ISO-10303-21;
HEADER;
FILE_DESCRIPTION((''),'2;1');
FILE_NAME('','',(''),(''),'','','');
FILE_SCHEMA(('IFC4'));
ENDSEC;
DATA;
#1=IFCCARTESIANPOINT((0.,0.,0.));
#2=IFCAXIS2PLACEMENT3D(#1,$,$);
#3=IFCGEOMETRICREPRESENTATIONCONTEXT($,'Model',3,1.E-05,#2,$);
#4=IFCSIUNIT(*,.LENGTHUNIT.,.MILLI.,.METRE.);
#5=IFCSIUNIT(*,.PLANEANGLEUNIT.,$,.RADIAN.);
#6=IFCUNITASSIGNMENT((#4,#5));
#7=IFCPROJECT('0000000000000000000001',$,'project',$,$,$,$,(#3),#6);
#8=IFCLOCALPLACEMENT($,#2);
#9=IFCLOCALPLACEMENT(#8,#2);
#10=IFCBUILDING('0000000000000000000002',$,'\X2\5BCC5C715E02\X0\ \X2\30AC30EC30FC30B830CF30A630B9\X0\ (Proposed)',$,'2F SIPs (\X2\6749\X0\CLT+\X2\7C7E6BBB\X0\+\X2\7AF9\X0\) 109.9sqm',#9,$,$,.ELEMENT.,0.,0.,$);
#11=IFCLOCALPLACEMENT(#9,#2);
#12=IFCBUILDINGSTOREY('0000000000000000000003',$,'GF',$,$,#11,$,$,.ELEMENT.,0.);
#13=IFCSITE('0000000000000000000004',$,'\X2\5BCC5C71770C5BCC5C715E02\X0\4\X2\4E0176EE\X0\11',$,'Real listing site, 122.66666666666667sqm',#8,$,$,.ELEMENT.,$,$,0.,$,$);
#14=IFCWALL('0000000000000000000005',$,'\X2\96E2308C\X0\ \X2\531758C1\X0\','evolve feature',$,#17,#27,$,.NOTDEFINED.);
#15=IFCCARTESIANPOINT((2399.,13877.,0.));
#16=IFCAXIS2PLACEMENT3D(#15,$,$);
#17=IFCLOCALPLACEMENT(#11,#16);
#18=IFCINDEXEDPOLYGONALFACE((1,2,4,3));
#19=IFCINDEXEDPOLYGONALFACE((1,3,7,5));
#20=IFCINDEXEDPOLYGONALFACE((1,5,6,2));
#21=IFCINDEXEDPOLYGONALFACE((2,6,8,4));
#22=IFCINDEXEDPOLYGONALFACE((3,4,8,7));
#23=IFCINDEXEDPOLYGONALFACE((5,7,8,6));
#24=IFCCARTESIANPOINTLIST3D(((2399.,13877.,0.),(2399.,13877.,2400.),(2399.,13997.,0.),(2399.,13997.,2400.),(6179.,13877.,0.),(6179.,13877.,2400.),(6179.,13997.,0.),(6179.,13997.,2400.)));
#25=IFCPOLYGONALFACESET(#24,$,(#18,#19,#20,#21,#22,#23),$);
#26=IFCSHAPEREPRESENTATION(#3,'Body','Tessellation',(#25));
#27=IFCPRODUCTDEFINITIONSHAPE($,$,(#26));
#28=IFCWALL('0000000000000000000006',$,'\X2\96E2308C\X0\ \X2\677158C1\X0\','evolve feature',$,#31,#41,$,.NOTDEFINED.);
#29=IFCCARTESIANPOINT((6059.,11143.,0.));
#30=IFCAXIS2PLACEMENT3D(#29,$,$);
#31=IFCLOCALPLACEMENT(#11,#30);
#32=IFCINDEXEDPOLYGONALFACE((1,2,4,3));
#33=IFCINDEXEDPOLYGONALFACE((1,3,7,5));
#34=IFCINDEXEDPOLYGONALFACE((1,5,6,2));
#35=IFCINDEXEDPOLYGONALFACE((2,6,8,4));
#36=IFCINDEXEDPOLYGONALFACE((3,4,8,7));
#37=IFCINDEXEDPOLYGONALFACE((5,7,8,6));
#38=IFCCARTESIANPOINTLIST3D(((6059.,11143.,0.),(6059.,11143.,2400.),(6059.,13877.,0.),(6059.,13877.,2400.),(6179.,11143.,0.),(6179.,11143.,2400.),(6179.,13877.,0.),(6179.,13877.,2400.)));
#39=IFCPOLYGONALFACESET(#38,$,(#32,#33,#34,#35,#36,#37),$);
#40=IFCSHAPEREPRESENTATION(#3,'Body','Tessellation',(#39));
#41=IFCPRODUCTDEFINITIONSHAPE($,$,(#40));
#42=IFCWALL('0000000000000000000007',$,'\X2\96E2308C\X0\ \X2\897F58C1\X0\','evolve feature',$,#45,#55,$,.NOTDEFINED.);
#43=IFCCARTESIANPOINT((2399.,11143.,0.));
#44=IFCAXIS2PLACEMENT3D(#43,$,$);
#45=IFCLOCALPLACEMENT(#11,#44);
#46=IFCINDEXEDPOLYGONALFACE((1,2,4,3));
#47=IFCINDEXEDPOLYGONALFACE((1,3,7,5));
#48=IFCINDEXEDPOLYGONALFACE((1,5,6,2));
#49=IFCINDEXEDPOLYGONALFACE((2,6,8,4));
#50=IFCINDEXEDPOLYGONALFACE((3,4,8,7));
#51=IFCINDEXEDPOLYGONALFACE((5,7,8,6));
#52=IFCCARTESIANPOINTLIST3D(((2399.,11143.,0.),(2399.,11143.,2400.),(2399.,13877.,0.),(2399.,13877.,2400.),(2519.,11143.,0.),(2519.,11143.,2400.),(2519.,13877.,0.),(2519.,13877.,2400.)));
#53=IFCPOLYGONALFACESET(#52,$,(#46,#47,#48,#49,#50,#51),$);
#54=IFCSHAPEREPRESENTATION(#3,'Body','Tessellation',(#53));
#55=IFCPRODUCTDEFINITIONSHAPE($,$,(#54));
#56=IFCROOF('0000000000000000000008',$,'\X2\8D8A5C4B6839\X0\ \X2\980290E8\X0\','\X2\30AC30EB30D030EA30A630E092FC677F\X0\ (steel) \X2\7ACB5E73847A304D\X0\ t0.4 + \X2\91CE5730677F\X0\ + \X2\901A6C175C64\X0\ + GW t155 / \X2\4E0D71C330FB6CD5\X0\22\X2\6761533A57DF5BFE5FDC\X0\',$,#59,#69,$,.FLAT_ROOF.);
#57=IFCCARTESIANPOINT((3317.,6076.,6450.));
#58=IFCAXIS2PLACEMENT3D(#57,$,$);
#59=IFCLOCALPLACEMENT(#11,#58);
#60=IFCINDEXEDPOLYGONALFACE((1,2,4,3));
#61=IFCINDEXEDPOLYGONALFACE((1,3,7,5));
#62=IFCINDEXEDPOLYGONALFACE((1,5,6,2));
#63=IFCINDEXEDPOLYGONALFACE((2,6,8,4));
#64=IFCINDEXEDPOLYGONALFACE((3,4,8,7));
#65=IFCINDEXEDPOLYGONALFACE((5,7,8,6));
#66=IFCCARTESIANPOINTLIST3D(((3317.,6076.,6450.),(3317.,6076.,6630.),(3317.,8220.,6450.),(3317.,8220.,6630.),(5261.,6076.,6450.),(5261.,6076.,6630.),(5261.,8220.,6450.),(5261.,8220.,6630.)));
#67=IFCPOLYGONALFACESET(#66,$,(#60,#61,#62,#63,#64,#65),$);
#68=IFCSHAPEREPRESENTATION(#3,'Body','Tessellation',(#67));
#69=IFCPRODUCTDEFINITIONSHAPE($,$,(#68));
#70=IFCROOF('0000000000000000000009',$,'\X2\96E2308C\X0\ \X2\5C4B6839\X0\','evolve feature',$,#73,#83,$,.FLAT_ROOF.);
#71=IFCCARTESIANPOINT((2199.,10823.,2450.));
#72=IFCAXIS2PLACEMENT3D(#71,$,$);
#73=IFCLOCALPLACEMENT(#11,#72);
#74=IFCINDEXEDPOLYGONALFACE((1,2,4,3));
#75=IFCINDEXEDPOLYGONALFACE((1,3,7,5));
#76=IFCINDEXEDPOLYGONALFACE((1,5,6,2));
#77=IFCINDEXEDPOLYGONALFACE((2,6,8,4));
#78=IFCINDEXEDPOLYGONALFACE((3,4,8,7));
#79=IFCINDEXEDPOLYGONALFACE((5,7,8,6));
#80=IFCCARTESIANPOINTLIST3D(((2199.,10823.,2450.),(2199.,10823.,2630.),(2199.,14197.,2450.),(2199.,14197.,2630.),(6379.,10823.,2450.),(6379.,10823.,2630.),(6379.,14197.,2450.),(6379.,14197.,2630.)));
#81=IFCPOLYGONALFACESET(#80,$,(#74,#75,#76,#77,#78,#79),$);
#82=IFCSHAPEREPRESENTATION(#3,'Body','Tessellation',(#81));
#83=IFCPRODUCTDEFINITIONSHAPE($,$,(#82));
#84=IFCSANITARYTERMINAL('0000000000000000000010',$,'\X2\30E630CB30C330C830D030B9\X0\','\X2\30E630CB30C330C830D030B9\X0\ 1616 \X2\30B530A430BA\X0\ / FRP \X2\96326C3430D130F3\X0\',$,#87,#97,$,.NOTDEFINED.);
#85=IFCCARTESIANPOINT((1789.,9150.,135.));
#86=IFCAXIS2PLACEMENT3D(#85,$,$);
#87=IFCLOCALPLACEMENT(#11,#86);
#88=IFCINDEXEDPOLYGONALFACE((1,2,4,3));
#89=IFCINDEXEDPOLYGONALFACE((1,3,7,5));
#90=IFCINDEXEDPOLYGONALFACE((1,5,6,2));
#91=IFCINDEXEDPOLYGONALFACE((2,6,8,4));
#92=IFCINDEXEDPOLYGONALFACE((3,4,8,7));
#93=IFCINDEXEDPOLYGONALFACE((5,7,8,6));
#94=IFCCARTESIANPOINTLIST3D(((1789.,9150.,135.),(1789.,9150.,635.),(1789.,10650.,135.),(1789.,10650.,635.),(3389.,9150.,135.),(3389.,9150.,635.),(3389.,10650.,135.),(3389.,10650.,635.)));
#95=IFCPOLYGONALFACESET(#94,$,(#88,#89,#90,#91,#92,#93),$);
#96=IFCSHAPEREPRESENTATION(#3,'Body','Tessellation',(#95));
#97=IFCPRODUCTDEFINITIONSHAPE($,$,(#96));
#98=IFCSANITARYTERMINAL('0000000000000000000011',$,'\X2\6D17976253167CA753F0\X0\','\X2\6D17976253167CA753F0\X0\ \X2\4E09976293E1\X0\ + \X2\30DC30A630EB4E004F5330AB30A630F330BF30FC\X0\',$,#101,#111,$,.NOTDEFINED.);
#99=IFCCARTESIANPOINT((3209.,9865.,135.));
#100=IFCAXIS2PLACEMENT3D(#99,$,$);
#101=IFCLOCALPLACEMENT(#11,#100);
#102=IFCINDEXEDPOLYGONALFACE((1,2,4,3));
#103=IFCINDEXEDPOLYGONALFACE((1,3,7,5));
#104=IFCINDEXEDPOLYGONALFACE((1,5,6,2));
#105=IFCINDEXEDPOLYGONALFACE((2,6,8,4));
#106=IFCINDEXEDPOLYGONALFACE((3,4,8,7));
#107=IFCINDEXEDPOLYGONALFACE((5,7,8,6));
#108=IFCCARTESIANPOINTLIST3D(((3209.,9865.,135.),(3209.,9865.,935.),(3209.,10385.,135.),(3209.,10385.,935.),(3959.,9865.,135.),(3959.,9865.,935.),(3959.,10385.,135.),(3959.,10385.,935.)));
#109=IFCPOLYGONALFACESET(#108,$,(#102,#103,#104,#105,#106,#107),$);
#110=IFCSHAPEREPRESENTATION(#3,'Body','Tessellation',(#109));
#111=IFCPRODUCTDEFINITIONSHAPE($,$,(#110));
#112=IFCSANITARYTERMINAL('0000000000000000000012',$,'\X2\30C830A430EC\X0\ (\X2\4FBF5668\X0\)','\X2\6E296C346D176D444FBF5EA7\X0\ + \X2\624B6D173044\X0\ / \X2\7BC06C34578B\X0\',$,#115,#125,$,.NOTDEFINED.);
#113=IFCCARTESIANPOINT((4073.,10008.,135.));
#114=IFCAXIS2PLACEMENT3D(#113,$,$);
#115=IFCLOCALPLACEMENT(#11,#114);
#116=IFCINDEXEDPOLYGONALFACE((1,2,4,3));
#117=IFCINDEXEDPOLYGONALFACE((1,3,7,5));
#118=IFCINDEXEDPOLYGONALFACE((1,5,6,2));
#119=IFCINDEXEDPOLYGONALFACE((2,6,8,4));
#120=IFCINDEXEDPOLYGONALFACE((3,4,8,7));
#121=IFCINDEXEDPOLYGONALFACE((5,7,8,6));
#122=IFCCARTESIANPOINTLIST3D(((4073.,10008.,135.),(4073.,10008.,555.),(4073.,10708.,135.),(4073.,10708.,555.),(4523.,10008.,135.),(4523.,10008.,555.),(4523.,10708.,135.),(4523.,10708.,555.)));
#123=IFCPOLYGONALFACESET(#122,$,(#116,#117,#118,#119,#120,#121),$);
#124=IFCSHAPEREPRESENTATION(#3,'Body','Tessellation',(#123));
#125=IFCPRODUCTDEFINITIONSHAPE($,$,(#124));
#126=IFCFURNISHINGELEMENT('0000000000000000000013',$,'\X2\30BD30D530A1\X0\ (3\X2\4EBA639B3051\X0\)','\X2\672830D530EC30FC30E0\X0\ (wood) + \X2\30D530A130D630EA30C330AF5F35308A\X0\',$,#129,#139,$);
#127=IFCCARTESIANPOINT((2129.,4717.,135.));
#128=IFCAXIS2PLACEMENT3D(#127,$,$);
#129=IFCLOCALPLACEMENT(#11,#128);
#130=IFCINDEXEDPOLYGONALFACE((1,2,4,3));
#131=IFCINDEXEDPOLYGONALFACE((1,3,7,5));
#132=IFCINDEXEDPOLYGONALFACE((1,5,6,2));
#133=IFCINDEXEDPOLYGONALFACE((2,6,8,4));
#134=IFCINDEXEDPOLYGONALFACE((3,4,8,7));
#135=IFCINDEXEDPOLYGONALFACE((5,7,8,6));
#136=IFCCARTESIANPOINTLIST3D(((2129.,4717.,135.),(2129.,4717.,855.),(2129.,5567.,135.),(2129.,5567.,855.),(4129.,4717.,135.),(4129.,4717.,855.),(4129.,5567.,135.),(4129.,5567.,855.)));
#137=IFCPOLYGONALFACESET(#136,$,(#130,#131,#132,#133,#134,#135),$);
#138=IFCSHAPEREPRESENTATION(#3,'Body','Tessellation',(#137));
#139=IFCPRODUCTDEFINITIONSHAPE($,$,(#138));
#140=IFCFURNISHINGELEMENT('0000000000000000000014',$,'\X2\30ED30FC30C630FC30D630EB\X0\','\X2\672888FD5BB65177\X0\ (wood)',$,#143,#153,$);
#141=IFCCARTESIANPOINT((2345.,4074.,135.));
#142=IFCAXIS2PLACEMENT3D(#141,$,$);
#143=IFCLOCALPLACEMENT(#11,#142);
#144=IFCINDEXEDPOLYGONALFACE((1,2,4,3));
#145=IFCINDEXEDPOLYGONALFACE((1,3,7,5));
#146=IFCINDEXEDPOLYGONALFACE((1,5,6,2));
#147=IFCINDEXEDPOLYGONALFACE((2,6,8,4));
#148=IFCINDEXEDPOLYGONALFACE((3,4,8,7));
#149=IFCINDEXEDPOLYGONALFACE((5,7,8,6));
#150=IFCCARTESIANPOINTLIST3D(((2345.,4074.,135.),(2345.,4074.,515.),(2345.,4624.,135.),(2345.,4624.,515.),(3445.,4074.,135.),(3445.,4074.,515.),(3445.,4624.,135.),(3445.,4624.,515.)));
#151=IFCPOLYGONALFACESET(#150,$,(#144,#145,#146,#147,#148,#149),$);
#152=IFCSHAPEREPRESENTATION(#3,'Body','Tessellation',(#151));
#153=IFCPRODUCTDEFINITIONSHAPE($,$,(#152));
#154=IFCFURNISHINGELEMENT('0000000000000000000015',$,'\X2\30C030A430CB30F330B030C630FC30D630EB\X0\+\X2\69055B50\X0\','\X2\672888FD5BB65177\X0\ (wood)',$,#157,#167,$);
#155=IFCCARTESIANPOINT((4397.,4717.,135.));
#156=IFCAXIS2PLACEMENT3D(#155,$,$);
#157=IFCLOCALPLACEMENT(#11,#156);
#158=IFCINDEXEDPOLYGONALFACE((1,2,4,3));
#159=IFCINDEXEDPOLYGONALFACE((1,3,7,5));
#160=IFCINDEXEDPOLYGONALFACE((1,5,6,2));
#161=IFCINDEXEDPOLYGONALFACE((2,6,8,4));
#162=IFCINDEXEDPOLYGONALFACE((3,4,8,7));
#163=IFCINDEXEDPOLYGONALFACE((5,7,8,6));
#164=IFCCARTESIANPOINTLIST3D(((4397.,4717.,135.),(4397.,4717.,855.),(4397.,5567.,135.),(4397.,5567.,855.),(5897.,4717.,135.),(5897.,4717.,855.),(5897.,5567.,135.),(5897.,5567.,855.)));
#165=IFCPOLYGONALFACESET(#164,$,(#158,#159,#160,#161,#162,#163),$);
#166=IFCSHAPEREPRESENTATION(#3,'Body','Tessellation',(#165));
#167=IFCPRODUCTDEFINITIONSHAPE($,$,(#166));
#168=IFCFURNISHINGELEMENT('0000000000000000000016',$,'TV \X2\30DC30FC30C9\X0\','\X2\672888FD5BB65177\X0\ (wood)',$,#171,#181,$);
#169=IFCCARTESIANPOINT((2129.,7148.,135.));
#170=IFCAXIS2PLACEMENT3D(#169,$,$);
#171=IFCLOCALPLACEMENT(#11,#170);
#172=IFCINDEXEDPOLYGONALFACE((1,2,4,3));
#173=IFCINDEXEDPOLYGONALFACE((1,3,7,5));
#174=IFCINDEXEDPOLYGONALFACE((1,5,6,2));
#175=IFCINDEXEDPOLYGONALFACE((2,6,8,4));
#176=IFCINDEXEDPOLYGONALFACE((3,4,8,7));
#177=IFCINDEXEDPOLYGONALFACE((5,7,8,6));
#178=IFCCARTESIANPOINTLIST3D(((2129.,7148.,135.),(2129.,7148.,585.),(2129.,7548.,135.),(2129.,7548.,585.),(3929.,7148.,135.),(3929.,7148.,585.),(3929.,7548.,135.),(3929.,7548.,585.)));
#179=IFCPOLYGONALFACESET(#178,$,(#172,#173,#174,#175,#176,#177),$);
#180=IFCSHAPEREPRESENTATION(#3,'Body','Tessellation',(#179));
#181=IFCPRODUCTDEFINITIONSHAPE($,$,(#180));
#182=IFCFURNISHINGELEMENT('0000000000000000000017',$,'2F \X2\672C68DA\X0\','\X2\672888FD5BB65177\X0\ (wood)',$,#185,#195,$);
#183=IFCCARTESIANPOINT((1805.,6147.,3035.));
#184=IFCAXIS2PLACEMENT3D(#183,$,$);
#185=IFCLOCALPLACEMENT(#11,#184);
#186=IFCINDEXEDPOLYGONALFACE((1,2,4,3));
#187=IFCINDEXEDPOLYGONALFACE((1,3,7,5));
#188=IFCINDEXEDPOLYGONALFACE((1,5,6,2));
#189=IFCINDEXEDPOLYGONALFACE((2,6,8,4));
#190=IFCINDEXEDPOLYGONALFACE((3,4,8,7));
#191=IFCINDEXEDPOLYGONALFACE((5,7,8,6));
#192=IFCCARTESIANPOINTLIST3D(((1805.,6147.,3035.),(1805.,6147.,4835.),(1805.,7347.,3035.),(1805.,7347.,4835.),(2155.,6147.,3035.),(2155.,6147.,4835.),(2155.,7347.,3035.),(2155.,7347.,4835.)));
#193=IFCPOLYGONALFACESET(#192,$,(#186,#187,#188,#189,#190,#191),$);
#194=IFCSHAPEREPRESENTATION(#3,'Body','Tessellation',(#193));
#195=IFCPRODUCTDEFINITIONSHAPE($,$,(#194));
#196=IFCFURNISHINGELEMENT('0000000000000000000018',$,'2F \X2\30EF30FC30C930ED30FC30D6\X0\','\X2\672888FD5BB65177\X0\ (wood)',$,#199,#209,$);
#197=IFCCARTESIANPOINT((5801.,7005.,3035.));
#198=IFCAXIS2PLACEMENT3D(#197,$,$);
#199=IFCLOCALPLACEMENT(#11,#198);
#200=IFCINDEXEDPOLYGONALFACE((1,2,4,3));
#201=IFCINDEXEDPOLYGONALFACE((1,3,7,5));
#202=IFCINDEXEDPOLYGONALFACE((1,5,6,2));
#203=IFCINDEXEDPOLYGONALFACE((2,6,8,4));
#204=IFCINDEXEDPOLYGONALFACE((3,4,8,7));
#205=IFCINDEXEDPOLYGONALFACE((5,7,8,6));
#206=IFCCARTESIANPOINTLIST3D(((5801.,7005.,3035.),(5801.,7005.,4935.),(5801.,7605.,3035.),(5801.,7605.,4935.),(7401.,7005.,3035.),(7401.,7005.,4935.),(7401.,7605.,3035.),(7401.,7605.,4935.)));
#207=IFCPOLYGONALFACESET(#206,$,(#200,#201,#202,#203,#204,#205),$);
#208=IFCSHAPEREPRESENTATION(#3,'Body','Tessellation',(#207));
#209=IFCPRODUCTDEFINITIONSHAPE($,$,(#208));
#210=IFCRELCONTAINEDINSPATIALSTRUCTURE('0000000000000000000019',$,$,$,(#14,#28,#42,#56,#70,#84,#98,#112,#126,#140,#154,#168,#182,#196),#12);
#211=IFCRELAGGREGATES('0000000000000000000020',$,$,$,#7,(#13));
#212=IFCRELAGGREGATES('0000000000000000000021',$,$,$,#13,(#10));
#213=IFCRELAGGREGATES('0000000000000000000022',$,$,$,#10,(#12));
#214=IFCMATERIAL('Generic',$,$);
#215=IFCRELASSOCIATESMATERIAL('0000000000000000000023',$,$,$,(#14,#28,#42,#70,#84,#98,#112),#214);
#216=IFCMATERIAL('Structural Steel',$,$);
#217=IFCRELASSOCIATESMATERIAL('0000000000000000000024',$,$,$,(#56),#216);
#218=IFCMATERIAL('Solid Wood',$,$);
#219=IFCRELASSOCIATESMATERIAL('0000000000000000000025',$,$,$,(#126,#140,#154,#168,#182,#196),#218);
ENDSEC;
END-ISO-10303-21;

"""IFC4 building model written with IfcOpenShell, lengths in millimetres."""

from ifc_helpers import new_model, si_unit, frame, frame_2d, origin, place, context, project, spatial, rectangle, extrude, material, element, save


model = new_model("IFC4")

# Units and contexts
model_context = context("Model", 3, precision=1e-05, world=origin())
ifc_project = project(units=[si_unit("LENGTHUNIT", "METRE", prefix="MILLI"), si_unit("PLANEANGLEUNIT", "RADIAN")], contexts=[model_context])

# Site, building, storey
site_placement = place(None, origin())
site = spatial("IfcSite", under=ifc_project, at=site_placement, Name="富山県富山市4丁目11", ObjectType="Real listing site, 122.66666666666667sqm", CompositionType="ELEMENT", RefElevation=0.0)
building_placement = place(site_placement, origin())
building = spatial("IfcBuilding", under=site, at=building_placement, Name="富山市 ガレージハウス (Proposed)", ObjectType="2F SIPs (杉CLT+籾殻+竹) 109.9sqm", CompositionType="ELEMENT", ElevationOfRefHeight=0.0, ElevationOfTerrain=0.0)
storey_placement = place(building_placement, origin())
storey = spatial("IfcBuildingStorey", under=building, at=storey_placement, Name="GF", CompositionType="ELEMENT", Elevation=0.0)

# Shared definitions
ifc_material_1 = material(Name="Generic")

# Shared definitions
ifc_material_2 = material(Name="Solid Wood")

# Walls
wall_1_placement = place(storey_placement, frame((2399.0, 13877.0, 0.0)))
element("IfcWall", 1, at=wall_1_placement, inside=storey, material=ifc_material_1, Name="離れ 北壁", Description="evolve feature", PredefinedType="NOTDEFINED", context=model_context, shape_type="SweptSolid", body=[
    extrude(rectangle(XDim=3780.0, YDim=120.0, at=frame_2d((1890.0, 60.0))), frame((2399.0, 13877.0, 0.0)), (0.0, 0.0, 1.0), 2400.0),
])
wall_2_placement = place(storey_placement, frame((6059.0, 11143.0, 0.0)))
element("IfcWall", 2, at=wall_2_placement, inside=storey, material=ifc_material_1, Name="離れ 東壁", Description="evolve feature", PredefinedType="NOTDEFINED", context=model_context, shape_type="SweptSolid", body=[
    extrude(rectangle(XDim=120.0, YDim=2734.0, at=frame_2d((60.0, 1367.0))), frame((6059.0, 11143.0, 0.0)), (0.0, 0.0, 1.0), 2400.0),
])
wall_3_placement = place(storey_placement, frame((2399.0, 11143.0, 0.0)))
element("IfcWall", 3, at=wall_3_placement, inside=storey, material=ifc_material_1, Name="離れ 西壁", Description="evolve feature", PredefinedType="NOTDEFINED", context=model_context, shape_type="SweptSolid", body=[
    extrude(rectangle(XDim=120.0, YDim=2734.0, at=frame_2d((60.0, 1367.0))), frame((2399.0, 11143.0, 0.0)), (0.0, 0.0, 1.0), 2400.0),
])

# Roofs
ifc_material_3 = material(Name="Structural Steel")
roof_1_placement = place(storey_placement, frame((3317.0, 6076.0, 6450.0)))
element("IfcRoof", 4, at=roof_1_placement, inside=storey, material=ifc_material_3, Name="越屋根 頂部", Description="ガルバリウム鋼板 (steel) 立平葺き t0.4 + 野地板 + 通気層 + GW t155 / 不燃・法22条区域対応", PredefinedType="FLAT_ROOF", context=model_context, shape_type="SweptSolid", body=[
    extrude(rectangle(XDim=1944.0, YDim=2144.0, at=frame_2d((972.0, 1072.0))), frame((3317.0, 6076.0, 6450.0)), (0.0, 0.0, 1.0), 180.0),
])
roof_2_placement = place(storey_placement, frame((2199.0, 10823.0, 2450.0)))
element("IfcRoof", 5, at=roof_2_placement, inside=storey, material=ifc_material_1, Name="離れ 屋根", Description="evolve feature", PredefinedType="FLAT_ROOF", context=model_context, shape_type="SweptSolid", body=[
    extrude(rectangle(XDim=4180.0, YDim=3374.0, at=frame_2d((2090.0, 1687.0))), frame((2199.0, 10823.0, 2450.0)), (0.0, 0.0, 1.0), 180.0),
])

# Sanitary terminals
sanitary_terminal_1_placement = place(storey_placement, frame((1789.0, 9150.0, 135.0)))
element("IfcSanitaryTerminal", 6, at=sanitary_terminal_1_placement, inside=storey, material=ifc_material_1, Name="ユニットバス", Description="ユニットバス 1616 サイズ / FRP 防水パン", PredefinedType="NOTDEFINED", context=model_context, shape_type="SweptSolid", body=[
    extrude(rectangle(XDim=1600.0, YDim=1500.0, at=frame_2d((800.0, 750.0))), frame((1789.0, 9150.0, 135.0)), (0.0, 0.0, 1.0), 500.0),
])
sanitary_terminal_2_placement = place(storey_placement, frame((3209.0, 9865.0, 135.0)))
element("IfcSanitaryTerminal", 7, at=sanitary_terminal_2_placement, inside=storey, material=ifc_material_1, Name="洗面化粧台", Description="洗面化粧台 三面鏡 + ボウル一体カウンター", PredefinedType="NOTDEFINED", context=model_context, shape_type="SweptSolid", body=[
    extrude(rectangle(XDim=750.0, YDim=520.0, at=frame_2d((375.0, 260.0))), frame((3209.0, 9865.0, 135.0)), (0.0, 0.0, 1.0), 800.0),
])
sanitary_terminal_3_placement = place(storey_placement, frame((4073.0, 10008.0, 135.0)))
element("IfcSanitaryTerminal", 8, at=sanitary_terminal_3_placement, inside=storey, material=ifc_material_1, Name="トイレ (便器)", Description="温水洗浄便座 + 手洗い / 節水型", PredefinedType="NOTDEFINED", context=model_context, shape_type="SweptSolid", body=[
    extrude(rectangle(XDim=450.0, YDim=700.0, at=frame_2d((225.0, 350.0))), frame((4073.0, 10008.0, 135.0)), (0.0, 0.0, 1.0), 420.0),
])

# Furnishing elements
furnishing_1_placement = place(storey_placement, frame((2129.0, 4717.0, 135.0)))
element("IfcFurnishingElement", 9, at=furnishing_1_placement, inside=storey, material=ifc_material_2, Name="ソファ (3人掛け)", Description="木フレーム (wood) + ファブリック張り", context=model_context, shape_type="SweptSolid", body=[
    extrude(rectangle(XDim=2000.0, YDim=850.0, at=frame_2d((1000.0, 425.0))), frame((2129.0, 4717.0, 135.0)), (0.0, 0.0, 1.0), 720.0),
])
furnishing_2_placement = place(storey_placement, frame((2345.0, 4074.0, 135.0)))
element("IfcFurnishingElement", 10, at=furnishing_2_placement, inside=storey, material=ifc_material_2, Name="ローテーブル", Description="木製家具 (wood)", context=model_context, shape_type="SweptSolid", body=[
    extrude(rectangle(XDim=1100.0, YDim=550.0, at=frame_2d((550.0, 275.0))), frame((2345.0, 4074.0, 135.0)), (0.0, 0.0, 1.0), 380.0),
])
furnishing_3_placement = place(storey_placement, frame((4397.0, 4717.0, 135.0)))
element("IfcFurnishingElement", 11, at=furnishing_3_placement, inside=storey, material=ifc_material_2, Name="ダイニングテーブル+椅子", Description="木製家具 (wood)", context=model_context, shape_type="SweptSolid", body=[
    extrude(rectangle(XDim=1500.0, YDim=850.0, at=frame_2d((750.0, 425.0))), frame((4397.0, 4717.0, 135.0)), (0.0, 0.0, 1.0), 720.0),
])
furnishing_4_placement = place(storey_placement, frame((2129.0, 7148.0, 135.0)))
element("IfcFurnishingElement", 12, at=furnishing_4_placement, inside=storey, material=ifc_material_2, Name="TV ボード", Description="木製家具 (wood)", context=model_context, shape_type="SweptSolid", body=[
    extrude(rectangle(XDim=1800.0, YDim=400.0, at=frame_2d((900.0, 200.0))), frame((2129.0, 7148.0, 135.0)), (0.0, 0.0, 1.0), 450.0),
])
furnishing_5_placement = place(storey_placement, frame((1805.0, 6147.0, 3035.0)))
element("IfcFurnishingElement", 13, at=furnishing_5_placement, inside=storey, material=ifc_material_2, Name="2F 本棚", Description="木製家具 (wood)", context=model_context, shape_type="SweptSolid", body=[
    extrude(rectangle(XDim=350.0, YDim=1200.0, at=frame_2d((175.0, 600.0))), frame((1805.0, 6147.0, 3035.0)), (0.0, 0.0, 1.0), 1800.0),
])
furnishing_6_placement = place(storey_placement, frame((5801.0, 7005.0, 3035.0)))
element("IfcFurnishingElement", 14, at=furnishing_6_placement, inside=storey, material=ifc_material_2, Name="2F ワードローブ", Description="木製家具 (wood)", context=model_context, shape_type="SweptSolid", body=[
    extrude(rectangle(XDim=1600.0, YDim=600.0, at=frame_2d((800.0, 300.0))), frame((5801.0, 7005.0, 3035.0)), (0.0, 0.0, 1.0), 1900.0),
])

save(model, "model.ifc")
